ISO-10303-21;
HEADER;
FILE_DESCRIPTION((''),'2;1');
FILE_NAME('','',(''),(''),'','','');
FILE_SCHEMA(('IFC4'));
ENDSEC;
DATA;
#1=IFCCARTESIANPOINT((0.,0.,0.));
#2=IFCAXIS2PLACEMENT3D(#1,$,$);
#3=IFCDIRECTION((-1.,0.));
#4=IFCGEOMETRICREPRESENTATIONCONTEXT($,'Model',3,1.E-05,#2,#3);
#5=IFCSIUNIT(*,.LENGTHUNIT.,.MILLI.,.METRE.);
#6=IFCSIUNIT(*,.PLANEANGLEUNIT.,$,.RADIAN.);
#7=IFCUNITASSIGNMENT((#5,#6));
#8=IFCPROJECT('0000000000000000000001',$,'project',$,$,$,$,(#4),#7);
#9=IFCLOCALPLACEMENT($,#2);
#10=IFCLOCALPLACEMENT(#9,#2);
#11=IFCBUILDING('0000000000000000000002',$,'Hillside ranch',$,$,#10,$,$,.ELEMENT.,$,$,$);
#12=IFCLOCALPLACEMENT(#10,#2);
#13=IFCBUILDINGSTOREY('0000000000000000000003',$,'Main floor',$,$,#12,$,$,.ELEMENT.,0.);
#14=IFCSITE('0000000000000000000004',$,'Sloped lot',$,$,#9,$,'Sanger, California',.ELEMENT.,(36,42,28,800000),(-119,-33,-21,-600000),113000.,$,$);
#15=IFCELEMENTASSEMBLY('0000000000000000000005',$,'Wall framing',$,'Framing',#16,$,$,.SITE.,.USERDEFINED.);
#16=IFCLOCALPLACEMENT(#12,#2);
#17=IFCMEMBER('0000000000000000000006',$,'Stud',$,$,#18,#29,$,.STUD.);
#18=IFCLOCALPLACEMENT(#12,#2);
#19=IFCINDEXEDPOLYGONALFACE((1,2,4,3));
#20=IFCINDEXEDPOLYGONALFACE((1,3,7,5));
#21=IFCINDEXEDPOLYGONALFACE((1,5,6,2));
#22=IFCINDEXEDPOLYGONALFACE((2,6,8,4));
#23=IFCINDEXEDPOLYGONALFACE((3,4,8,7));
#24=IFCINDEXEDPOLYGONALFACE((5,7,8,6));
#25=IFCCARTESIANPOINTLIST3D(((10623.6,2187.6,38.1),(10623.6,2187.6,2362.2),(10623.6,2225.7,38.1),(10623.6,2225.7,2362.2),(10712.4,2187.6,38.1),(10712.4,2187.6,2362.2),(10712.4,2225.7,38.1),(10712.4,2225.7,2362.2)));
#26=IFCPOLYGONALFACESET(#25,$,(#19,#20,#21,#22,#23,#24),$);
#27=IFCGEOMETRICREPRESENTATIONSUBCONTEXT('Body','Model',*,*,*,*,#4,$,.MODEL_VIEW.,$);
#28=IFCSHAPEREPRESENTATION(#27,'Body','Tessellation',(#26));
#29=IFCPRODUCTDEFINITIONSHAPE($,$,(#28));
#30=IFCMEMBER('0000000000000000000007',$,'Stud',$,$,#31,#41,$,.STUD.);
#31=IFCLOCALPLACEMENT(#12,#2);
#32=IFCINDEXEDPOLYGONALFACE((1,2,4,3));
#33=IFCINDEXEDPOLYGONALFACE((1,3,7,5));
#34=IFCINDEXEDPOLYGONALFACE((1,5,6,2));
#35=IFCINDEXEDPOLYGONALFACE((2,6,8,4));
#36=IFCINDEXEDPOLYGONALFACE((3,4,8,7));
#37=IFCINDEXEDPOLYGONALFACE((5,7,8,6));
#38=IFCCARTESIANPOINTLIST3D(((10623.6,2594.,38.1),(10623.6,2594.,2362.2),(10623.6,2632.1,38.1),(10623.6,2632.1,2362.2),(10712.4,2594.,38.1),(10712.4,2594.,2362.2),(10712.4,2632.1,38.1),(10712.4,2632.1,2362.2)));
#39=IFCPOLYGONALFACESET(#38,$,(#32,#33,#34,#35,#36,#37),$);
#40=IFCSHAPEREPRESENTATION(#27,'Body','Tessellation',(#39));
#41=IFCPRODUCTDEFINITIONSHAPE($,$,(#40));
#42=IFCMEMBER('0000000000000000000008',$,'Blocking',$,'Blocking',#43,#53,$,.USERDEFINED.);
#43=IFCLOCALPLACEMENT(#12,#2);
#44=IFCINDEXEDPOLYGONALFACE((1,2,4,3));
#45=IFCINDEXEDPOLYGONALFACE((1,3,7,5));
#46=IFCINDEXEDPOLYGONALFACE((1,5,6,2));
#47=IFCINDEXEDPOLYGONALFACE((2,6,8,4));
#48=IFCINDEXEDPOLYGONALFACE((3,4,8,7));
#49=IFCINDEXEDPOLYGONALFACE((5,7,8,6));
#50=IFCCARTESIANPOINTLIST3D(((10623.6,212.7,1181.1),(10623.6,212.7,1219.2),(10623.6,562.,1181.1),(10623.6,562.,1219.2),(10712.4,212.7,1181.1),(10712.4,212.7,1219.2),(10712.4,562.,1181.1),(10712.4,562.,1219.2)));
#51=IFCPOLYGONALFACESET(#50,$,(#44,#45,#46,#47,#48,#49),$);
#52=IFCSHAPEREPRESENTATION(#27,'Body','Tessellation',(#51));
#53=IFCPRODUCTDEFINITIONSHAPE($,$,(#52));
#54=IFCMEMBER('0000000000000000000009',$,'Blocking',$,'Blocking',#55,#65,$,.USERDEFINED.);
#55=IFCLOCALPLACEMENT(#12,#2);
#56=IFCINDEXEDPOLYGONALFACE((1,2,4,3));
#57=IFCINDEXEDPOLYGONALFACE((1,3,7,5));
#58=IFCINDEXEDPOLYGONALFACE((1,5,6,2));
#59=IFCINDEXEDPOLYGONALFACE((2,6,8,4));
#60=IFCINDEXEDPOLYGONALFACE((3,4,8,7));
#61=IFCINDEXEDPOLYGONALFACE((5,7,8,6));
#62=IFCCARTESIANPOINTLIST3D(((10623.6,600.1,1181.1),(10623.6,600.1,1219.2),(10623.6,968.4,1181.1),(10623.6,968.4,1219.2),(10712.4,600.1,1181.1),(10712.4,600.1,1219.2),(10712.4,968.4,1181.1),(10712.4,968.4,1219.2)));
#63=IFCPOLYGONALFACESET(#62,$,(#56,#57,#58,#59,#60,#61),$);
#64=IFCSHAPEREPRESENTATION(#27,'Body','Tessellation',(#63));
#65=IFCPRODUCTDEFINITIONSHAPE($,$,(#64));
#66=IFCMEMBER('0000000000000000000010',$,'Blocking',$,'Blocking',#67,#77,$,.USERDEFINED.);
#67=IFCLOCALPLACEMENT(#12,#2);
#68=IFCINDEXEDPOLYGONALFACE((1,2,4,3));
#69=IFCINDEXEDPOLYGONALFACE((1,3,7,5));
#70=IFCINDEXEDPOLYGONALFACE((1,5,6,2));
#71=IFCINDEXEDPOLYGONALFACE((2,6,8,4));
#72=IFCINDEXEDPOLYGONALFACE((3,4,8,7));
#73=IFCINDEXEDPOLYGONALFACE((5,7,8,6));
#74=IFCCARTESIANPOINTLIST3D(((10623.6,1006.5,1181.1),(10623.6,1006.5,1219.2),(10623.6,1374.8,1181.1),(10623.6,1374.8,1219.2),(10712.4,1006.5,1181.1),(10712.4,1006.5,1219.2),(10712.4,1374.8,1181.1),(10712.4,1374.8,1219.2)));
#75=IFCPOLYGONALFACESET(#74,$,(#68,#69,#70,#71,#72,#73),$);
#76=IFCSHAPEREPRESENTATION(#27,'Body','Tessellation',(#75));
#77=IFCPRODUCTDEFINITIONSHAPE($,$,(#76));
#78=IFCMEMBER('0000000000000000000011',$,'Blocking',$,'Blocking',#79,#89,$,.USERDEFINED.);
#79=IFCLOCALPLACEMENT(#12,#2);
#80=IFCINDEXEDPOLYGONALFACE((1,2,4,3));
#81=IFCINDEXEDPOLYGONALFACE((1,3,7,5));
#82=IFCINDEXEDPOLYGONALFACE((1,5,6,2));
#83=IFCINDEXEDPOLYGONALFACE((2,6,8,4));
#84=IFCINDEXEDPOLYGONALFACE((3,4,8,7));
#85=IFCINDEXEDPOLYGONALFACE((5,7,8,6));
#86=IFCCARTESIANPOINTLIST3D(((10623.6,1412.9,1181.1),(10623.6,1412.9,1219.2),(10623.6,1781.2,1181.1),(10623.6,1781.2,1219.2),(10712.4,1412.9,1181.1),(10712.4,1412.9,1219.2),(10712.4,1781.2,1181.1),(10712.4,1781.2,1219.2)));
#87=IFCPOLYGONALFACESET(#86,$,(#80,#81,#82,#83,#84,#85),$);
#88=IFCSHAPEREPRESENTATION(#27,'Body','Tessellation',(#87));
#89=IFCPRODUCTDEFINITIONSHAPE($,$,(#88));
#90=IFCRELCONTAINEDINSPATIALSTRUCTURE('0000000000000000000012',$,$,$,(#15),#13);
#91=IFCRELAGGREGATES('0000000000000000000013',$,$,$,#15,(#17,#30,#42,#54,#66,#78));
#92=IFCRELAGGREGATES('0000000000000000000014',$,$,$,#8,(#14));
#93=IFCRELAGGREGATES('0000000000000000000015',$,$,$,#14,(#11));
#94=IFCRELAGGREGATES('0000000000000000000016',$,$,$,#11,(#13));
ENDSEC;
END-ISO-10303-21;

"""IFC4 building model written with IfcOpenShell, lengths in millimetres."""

from ifc_helpers import new_model, si_unit, direction, frame, origin, origin_with_axes, place, context, subcontext, project, spatial, polyline, outline, extrude, element, aggregate, save


model = new_model("IFC4")

# Units and contexts
model_context = context("Model", 3, precision=1e-05, world=origin(), true_north=direction((-1.0, 0.0)))
body_context = subcontext(model_context, "Body", "Model", "MODEL_VIEW")
ifc_project = project(units=[si_unit("LENGTHUNIT", "METRE", prefix="MILLI"), si_unit("PLANEANGLEUNIT", "RADIAN")], contexts=[model_context])

# Site, building, storey
site_placement = place(None, origin())
site = spatial("IfcSite", under=ifc_project, at=site_placement, Name="Sloped lot", LongName="Sanger, California", CompositionType="ELEMENT", RefLatitude=(36, 42, 28, 800000), RefLongitude=(-119, -33, -21, -600000), RefElevation=113000.0)
building_placement = place(site_placement, origin())
building = spatial("IfcBuilding", under=site, at=building_placement, Name="Hillside ranch", CompositionType="ELEMENT")
storey_placement = place(building_placement, origin())
storey = spatial("IfcBuildingStorey", under=building, at=storey_placement, Name="Main floor", CompositionType="ELEMENT", Elevation=0.0)

# Element assembly, members
assembly_placement = place(storey_placement, origin_with_axes())
assembly = element("IfcElementAssembly", 1, at=assembly_placement, inside=storey, Name="Wall framing", ObjectType="Framing", AssemblyPlace="SITE", PredefinedType="USERDEFINED")
member_1_placement = place(storey_placement, origin_with_axes())
member_1 = element("IfcMember", 2, at=member_1_placement, Name="Stud", PredefinedType="STUD", context=body_context, shape_type="SweptSolid", body=[
    extrude(outline(polyline([(0.0, 0.0), (38.1, 0.0), (38.1, 88.9), (0.0, 88.9), (0.0, 0.0)])), frame((10712.5, 2187.6, 38.1), z_axis=(0.0, 0.0, 1.0), x_axis=(0.0, 1.0, 0.0)), (0.0, 0.0, 1.0), 2324.1),
])
member_2_placement = place(storey_placement, origin_with_axes())
member_2 = element("IfcMember", 3, at=member_2_placement, Name="Stud", PredefinedType="STUD", context=body_context, shape_type="SweptSolid", body=[
    extrude(outline(polyline([(0.0, 0.0), (38.1, 0.0), (38.1, 88.9), (0.0, 88.9), (0.0, 0.0)])), frame((10712.5, 2594.0, 38.1), z_axis=(0.0, 0.0, 1.0), x_axis=(0.0, 1.0, 0.0)), (0.0, 0.0, 1.0), 2324.1),
])
member_3_placement = place(storey_placement, origin_with_axes())
member_3 = element("IfcMember", 4, at=member_3_placement, Name="Blocking", ObjectType="Blocking", PredefinedType="USERDEFINED", context=body_context, shape_type="SweptSolid", body=[
    extrude(outline(polyline([(0.0, 0.0), (349.2, 0.0), (349.2, 88.9), (0.0, 88.9), (0.0, 0.0)])), frame((10712.5, 212.7, 1181.1), z_axis=(0.0, 0.0, 1.0), x_axis=(0.0, 1.0, 0.0)), (0.0, 0.0, 1.0), 38.1),
])
member_4_placement = place(storey_placement, origin_with_axes())
member_4 = element("IfcMember", 5, at=member_4_placement, Name="Blocking", ObjectType="Blocking", PredefinedType="USERDEFINED", context=body_context, shape_type="SweptSolid", body=[
    extrude(outline(polyline([(0.0, 0.0), (368.3, 0.0), (368.3, 88.9), (0.0, 88.9), (0.0, 0.0)])), frame((10712.5, 600.1, 1181.1), z_axis=(0.0, 0.0, 1.0), x_axis=(0.0, 1.0, 0.0)), (0.0, 0.0, 1.0), 38.1),
])
member_5_placement = place(storey_placement, origin_with_axes())
member_5 = element("IfcMember", 6, at=member_5_placement, Name="Blocking", ObjectType="Blocking", PredefinedType="USERDEFINED", context=body_context, shape_type="SweptSolid", body=[
    extrude(outline(polyline([(0.0, 0.0), (368.3, 0.0), (368.3, 88.9), (0.0, 88.9), (0.0, 0.0)])), frame((10712.5, 1006.5, 1181.1), z_axis=(0.0, 0.0, 1.0), x_axis=(0.0, 1.0, 0.0)), (0.0, 0.0, 1.0), 38.1),
])
member_6_placement = place(storey_placement, origin_with_axes())
member_6 = element("IfcMember", 7, at=member_6_placement, Name="Blocking", ObjectType="Blocking", PredefinedType="USERDEFINED", context=body_context, shape_type="SweptSolid", body=[
    extrude(outline(polyline([(0.0, 0.0), (368.3, 0.0), (368.3, 88.9), (0.0, 88.9), (0.0, 0.0)])), frame((10712.5, 1412.9, 1181.1), z_axis=(0.0, 0.0, 1.0), x_axis=(0.0, 1.0, 0.0)), (0.0, 0.0, 1.0), 38.1),
])
aggregate(assembly, [member_1, member_2, member_3, member_4, member_5, member_6])

save(model, "model.ifc")
